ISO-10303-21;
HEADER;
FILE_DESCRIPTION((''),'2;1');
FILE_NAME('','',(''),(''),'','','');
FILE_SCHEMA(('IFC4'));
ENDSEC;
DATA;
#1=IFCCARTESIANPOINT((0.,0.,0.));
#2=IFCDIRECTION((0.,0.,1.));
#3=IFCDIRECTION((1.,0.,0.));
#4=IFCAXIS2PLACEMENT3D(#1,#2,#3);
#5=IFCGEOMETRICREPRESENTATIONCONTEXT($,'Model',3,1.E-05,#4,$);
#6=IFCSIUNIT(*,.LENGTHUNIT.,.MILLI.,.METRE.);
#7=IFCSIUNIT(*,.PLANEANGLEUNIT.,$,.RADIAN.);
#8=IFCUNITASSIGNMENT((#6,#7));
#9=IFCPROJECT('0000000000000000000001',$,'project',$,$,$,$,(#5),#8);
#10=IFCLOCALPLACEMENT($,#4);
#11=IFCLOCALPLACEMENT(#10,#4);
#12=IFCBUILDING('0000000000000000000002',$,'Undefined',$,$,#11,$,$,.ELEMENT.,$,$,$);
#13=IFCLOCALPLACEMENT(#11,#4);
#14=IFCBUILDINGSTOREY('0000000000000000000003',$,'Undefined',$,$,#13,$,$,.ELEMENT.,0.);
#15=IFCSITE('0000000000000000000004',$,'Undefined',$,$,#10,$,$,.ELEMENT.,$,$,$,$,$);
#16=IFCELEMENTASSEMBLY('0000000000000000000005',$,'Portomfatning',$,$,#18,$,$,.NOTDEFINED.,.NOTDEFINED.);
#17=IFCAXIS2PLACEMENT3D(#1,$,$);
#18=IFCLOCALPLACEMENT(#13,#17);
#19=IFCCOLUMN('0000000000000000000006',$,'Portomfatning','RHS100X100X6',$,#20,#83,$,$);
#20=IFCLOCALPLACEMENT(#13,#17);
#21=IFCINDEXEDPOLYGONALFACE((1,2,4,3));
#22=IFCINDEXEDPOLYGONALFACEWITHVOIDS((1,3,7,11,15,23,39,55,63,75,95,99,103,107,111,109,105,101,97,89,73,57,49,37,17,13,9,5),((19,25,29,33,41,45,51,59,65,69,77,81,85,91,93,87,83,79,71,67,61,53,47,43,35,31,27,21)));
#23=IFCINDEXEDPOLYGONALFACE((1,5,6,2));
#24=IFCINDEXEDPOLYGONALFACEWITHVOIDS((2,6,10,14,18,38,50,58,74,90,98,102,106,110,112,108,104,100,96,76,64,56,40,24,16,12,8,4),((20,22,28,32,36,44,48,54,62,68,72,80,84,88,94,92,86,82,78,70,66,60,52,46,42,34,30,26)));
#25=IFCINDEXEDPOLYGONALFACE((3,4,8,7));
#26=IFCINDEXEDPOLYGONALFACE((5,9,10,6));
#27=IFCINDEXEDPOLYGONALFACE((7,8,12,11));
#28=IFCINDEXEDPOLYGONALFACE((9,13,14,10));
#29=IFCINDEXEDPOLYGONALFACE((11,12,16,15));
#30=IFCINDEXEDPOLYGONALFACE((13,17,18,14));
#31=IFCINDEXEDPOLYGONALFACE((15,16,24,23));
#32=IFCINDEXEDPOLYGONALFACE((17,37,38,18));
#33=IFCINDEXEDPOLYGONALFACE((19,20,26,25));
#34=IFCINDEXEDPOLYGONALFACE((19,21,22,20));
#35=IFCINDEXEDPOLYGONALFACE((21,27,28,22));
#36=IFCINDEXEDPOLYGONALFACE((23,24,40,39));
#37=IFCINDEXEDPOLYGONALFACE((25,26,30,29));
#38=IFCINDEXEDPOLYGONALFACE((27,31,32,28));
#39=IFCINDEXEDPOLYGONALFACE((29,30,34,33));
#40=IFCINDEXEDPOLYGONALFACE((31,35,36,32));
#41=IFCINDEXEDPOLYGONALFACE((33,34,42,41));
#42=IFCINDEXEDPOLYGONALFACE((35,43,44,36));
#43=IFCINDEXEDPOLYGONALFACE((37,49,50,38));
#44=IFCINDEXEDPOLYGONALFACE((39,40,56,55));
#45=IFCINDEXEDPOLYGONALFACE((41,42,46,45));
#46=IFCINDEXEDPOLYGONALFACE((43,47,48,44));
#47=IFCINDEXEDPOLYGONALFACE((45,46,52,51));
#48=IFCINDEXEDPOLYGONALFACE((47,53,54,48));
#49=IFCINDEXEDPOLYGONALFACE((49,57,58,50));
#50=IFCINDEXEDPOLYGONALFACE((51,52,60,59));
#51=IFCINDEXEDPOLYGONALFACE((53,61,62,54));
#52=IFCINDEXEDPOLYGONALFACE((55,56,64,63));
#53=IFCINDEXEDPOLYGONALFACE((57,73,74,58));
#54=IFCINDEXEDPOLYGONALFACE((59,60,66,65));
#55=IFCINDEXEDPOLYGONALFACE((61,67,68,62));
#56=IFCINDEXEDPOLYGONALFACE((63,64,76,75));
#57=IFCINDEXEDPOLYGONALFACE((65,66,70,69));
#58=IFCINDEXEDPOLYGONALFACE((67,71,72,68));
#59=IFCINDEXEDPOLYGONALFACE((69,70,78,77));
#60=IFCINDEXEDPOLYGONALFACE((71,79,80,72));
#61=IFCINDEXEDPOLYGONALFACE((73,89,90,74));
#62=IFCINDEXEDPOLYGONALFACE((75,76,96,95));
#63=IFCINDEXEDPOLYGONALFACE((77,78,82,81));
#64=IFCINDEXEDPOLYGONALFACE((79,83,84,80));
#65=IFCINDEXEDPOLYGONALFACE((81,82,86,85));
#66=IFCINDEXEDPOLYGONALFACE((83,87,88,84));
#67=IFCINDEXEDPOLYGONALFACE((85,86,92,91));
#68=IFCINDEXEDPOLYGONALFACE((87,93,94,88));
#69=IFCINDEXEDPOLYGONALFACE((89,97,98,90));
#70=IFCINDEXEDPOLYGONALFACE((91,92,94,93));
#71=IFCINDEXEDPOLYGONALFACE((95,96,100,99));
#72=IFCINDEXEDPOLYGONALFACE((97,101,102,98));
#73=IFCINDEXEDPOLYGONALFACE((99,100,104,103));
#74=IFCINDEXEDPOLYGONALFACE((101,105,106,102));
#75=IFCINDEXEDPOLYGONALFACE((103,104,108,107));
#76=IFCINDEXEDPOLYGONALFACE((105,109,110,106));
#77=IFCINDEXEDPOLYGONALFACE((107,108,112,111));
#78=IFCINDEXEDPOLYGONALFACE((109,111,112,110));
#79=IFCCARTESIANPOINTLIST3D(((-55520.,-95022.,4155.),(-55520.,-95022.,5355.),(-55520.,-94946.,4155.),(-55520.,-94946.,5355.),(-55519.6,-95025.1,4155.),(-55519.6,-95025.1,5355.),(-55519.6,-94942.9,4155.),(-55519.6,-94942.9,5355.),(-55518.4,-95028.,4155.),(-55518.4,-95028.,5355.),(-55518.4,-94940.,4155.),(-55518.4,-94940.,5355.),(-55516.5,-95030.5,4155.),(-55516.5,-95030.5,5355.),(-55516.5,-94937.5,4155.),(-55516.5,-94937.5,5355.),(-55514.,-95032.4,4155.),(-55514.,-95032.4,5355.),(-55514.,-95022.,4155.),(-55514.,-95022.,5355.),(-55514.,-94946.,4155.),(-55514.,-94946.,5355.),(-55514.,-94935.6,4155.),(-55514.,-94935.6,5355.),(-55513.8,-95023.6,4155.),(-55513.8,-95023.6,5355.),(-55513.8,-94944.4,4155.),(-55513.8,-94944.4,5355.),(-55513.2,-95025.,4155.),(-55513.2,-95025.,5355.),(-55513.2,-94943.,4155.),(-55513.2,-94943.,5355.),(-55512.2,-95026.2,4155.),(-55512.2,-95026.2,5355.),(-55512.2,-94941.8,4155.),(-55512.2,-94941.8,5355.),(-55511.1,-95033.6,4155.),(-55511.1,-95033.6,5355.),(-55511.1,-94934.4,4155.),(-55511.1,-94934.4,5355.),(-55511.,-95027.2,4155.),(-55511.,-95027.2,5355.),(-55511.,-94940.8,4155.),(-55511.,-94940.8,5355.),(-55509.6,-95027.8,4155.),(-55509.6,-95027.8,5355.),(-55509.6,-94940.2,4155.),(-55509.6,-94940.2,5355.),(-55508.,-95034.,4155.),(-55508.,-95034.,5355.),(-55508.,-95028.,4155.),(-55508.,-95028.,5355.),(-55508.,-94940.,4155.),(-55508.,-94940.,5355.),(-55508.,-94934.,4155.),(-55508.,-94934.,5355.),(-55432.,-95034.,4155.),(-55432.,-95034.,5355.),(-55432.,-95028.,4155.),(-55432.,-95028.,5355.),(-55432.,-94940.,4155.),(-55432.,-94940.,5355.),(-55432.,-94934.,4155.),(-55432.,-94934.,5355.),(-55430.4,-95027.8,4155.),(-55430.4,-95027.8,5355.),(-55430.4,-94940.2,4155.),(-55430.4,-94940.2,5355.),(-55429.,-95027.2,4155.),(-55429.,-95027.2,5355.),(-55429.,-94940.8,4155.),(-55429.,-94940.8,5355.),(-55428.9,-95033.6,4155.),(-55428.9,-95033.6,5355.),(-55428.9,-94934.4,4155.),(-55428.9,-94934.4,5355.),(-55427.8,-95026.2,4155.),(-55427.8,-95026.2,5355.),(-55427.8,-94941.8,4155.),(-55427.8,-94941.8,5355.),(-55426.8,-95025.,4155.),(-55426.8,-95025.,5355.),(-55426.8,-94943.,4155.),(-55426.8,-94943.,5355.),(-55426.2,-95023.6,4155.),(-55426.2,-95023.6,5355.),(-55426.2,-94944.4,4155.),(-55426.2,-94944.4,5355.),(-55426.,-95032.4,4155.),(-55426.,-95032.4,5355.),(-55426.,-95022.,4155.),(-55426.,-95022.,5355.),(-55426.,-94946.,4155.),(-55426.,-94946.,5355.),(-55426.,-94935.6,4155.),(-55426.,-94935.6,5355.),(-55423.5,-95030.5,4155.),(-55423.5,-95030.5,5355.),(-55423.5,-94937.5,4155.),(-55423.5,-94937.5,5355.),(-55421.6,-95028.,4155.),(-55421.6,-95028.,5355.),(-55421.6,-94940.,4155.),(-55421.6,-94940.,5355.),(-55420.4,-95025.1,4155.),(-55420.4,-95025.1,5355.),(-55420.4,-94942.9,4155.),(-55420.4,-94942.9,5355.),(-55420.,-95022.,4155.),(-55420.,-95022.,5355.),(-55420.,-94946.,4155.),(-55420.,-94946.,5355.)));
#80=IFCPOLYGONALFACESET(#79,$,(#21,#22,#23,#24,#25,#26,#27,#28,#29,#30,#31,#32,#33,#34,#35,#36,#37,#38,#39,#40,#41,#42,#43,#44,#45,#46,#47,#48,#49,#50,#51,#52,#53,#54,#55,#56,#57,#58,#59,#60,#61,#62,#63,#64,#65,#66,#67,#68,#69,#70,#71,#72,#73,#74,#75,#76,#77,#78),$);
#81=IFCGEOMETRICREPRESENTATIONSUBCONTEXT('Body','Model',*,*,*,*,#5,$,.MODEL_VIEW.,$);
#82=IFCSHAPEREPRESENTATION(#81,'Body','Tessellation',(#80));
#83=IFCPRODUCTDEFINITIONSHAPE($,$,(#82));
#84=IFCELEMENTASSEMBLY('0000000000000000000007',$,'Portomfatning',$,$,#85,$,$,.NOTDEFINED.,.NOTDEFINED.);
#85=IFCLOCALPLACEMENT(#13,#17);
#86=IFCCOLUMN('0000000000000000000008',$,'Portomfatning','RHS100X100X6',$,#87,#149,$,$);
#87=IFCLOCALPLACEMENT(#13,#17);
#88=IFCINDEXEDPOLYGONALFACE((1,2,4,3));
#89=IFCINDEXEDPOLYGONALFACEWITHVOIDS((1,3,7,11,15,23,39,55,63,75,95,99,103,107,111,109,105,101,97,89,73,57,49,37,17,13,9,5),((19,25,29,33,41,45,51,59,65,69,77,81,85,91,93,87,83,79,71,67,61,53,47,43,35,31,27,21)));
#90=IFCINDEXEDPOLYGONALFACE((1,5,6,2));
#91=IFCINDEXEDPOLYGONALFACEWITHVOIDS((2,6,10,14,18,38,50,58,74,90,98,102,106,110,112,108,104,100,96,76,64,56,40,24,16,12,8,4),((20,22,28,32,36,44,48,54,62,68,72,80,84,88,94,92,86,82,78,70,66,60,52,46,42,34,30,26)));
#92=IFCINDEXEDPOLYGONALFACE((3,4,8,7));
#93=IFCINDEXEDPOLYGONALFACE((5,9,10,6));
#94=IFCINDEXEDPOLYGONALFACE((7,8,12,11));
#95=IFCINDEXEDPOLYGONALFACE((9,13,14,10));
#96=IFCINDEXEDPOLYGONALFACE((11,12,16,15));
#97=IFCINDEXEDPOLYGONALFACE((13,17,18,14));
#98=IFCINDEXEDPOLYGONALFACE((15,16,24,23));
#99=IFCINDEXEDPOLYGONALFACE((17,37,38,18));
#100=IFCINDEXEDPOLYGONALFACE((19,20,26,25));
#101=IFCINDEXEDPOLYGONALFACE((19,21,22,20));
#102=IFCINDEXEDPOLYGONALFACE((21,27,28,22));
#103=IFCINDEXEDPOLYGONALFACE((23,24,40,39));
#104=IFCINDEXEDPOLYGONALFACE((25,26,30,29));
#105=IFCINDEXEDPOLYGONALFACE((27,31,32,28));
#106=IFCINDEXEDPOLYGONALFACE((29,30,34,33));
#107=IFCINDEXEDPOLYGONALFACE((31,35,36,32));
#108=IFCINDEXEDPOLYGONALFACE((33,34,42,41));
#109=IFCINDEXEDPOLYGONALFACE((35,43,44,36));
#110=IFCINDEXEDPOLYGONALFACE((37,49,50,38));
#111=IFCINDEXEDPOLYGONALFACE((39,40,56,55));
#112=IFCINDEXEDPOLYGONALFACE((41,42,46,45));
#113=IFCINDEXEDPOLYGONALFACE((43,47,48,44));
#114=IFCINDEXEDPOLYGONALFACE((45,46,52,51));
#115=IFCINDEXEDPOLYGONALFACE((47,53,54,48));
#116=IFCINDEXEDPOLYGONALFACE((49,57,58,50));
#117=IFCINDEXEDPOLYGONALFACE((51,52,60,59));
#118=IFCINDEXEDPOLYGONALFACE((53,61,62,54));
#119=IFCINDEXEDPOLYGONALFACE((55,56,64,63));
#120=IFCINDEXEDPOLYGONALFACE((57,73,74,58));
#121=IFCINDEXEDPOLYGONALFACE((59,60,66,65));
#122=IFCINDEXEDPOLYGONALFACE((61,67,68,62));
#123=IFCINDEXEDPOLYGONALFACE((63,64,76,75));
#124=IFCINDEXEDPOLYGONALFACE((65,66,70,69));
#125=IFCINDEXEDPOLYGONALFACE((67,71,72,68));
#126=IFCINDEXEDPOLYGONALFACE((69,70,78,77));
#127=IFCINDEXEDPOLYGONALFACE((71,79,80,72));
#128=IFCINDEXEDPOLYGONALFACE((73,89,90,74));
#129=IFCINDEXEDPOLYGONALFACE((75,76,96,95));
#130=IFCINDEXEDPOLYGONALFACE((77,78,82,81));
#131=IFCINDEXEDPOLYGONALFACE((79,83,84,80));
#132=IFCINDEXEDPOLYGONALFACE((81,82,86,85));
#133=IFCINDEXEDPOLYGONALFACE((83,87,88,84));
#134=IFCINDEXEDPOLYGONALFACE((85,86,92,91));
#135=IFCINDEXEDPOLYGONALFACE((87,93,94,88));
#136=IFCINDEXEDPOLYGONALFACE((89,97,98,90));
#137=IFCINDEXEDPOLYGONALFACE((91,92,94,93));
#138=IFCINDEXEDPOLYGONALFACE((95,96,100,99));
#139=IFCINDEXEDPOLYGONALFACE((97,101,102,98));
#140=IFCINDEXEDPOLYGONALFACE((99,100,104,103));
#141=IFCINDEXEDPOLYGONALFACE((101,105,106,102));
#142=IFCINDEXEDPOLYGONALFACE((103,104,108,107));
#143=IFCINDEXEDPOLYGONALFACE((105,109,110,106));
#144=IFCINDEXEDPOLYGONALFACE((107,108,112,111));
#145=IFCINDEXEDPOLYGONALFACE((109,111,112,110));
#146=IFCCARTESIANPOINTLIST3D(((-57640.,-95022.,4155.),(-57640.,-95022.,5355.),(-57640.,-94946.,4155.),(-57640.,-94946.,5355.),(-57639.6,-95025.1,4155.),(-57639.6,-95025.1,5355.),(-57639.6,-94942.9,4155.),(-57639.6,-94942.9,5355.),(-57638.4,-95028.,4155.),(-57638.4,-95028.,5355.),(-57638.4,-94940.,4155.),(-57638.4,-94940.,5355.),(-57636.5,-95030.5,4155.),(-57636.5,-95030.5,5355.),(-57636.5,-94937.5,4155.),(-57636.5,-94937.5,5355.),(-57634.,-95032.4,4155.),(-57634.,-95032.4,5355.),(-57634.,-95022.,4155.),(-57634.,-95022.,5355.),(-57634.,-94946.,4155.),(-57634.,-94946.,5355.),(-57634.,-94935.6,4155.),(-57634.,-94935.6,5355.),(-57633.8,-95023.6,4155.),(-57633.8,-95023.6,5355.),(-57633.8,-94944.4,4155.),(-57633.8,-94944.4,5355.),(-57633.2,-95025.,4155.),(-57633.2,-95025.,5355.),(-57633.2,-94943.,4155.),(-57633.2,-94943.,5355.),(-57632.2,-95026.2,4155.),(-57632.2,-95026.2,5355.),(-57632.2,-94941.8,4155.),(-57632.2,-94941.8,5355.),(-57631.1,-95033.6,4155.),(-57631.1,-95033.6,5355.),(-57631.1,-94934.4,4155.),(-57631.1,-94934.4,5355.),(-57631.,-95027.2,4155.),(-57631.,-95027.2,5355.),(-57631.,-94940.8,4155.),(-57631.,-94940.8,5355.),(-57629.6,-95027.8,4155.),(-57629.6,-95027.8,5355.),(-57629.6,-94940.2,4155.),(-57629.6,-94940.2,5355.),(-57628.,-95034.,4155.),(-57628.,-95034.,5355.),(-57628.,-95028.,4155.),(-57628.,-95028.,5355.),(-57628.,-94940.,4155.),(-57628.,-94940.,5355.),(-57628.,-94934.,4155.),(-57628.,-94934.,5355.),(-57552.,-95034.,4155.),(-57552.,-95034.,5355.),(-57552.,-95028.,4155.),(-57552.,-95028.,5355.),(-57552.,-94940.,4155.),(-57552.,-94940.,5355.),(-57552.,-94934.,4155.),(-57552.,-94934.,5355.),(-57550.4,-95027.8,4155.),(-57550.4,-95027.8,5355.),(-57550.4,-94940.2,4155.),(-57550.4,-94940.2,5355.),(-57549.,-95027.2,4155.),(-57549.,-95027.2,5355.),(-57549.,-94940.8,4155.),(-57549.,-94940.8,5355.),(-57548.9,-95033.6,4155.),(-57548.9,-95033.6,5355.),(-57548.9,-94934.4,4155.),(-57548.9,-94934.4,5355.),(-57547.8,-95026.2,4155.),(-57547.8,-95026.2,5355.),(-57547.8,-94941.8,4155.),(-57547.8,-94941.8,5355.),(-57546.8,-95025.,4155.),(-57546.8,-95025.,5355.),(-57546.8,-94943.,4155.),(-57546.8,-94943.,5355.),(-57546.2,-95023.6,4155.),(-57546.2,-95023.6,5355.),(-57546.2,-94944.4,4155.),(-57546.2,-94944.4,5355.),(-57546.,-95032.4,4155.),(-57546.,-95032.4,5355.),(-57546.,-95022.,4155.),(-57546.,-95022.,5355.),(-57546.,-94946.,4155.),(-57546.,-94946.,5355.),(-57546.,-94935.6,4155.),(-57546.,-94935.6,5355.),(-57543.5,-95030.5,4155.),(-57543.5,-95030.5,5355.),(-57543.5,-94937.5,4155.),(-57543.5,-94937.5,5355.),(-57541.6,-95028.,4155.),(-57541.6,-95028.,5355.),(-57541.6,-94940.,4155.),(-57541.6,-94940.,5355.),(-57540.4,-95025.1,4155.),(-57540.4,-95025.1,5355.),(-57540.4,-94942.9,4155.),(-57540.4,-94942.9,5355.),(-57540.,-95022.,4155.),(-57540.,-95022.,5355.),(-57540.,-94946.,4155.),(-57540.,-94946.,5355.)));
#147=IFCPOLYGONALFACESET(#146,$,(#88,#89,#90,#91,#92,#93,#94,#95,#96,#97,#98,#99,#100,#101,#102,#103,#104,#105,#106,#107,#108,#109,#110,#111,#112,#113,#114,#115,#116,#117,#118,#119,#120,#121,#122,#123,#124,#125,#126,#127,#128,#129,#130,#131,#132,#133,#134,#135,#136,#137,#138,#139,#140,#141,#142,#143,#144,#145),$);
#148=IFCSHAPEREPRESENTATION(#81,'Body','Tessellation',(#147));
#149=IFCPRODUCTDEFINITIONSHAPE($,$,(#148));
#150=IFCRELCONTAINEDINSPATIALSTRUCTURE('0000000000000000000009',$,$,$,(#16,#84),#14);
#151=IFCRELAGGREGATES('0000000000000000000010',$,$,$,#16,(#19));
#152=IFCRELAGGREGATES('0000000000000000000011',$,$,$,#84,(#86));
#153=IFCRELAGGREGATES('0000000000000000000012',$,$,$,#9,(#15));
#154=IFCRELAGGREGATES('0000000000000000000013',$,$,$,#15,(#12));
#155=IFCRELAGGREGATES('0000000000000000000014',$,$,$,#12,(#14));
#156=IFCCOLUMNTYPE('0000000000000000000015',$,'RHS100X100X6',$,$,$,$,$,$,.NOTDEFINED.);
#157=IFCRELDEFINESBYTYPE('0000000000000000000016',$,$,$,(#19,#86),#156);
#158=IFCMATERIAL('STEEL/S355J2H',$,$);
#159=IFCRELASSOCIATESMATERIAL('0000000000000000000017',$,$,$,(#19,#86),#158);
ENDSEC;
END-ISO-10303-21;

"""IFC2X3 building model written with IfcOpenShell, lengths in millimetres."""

from ifc_helpers import new_model, si_unit, frame, origin_with_axes, origin_2d_with_axis, place, context, subcontext, project, spatial, hollow_rectangle, extrude, clip, halfspace, material, type_object, element, aggregate, save


model = new_model("IFC2X3")

# Units and contexts
model_context = context("Model", 3, precision=1e-05, world=origin_with_axes())
body_context = subcontext(model_context, "Body", "Model", "MODEL_VIEW")
ifc_project = project(units=[si_unit("LENGTHUNIT", "METRE", prefix="MILLI"), si_unit("PLANEANGLEUNIT", "RADIAN")], contexts=[model_context])

# Site, building, storey
site_placement = place(None, origin_with_axes())
site = spatial("IfcSite", under=ifc_project, at=site_placement, Name="Undefined", CompositionType="ELEMENT")
building_placement = place(site_placement, origin_with_axes())
building = spatial("IfcBuilding", under=site, at=building_placement, Name="Undefined", CompositionType="ELEMENT")
storey_placement = place(building_placement, origin_with_axes())
storey = spatial("IfcBuildingStorey", under=building, at=storey_placement, Name="Undefined", CompositionType="ELEMENT", Elevation=0.0)

# Element assemblies, columns
assembly_1_placement = place(storey_placement, origin_with_axes())
assembly_1 = element("IfcElementAssembly", 1, at=assembly_1_placement, inside=storey, Name="Portomfatning", AssemblyPlace="NOTDEFINED", PredefinedType="NOTDEFINED")
ifc_material_1 = material(Name="STEEL/S355J2H")
column_type = type_object("IfcColumnType", Name="RHS100X100X6", PredefinedType="NOTDEFINED")
column_1_placement = place(assembly_1_placement, frame((-55470.0, -94984.0, 4160.0), z_axis=(0.0, 0.0, 1.0), x_axis=(0.0, -1.0, 0.0)))
column_1 = element("IfcColumn", 2, at=column_1_placement, type_object=column_type, material=ifc_material_1, Name="Portomfatning", Description="RHS100X100X6", context=body_context, shape_type="Clipping", body=[
    clip(clip(extrude(hollow_rectangle(XDim=100.0, YDim=100.0, WallThickness=6.0, InnerFilletRadius=6.0, OuterFilletRadius=12.0, at=origin_2d_with_axis()), frame((0.0, 0.0, 1195.0), z_axis=(0.0, 0.0, -1.0), x_axis=(0.0, 1.0, 0.0)), (0.0, 0.0, 1.0), 1200.0), halfspace(frame((0.0, -50.0, 1195.0), z_axis=(0.0, 0.0, -1.0), x_axis=(1.0, 0.0, 0.0)), True)), halfspace(frame((0.0, -50.0, -5.0), z_axis=(0.0, 0.0, 1.0), x_axis=(-1.0, 0.0, 0.0)), True)),
])
assembly_2_placement = place(storey_placement, origin_with_axes())
assembly_2 = element("IfcElementAssembly", 3, at=assembly_2_placement, inside=storey, Name="Portomfatning", AssemblyPlace="NOTDEFINED", PredefinedType="NOTDEFINED")
column_2_placement = place(assembly_2_placement, frame((-57590.0, -94984.0, 4160.0), z_axis=(0.0, 0.0, 1.0), x_axis=(0.0, -1.0, 0.0)))
column_2 = element("IfcColumn", 4, at=column_2_placement, type_object=column_type, material=ifc_material_1, Name="Portomfatning", Description="RHS100X100X6", context=body_context, shape_type="Clipping", body=[
    clip(clip(extrude(hollow_rectangle(XDim=100.0, YDim=100.0, WallThickness=6.0, InnerFilletRadius=6.0, OuterFilletRadius=12.0, at=origin_2d_with_axis()), frame((0.0, 0.0, 1195.0), z_axis=(0.0, 0.0, -1.0), x_axis=(0.0, 1.0, 0.0)), (0.0, 0.0, 1.0), 1200.0), halfspace(frame((0.0, 50.0, 1195.0), z_axis=(0.0, 0.0, -1.0), x_axis=(-1.0, 0.0, 0.0)), True)), halfspace(frame((0.0, 50.0, -5.0), z_axis=(0.0, 0.0, 1.0), x_axis=(1.0, 0.0, 0.0)), True)),
])

aggregate(assembly_1, [column_1])
aggregate(assembly_2, [column_2])

save(model, "model.ifc")
